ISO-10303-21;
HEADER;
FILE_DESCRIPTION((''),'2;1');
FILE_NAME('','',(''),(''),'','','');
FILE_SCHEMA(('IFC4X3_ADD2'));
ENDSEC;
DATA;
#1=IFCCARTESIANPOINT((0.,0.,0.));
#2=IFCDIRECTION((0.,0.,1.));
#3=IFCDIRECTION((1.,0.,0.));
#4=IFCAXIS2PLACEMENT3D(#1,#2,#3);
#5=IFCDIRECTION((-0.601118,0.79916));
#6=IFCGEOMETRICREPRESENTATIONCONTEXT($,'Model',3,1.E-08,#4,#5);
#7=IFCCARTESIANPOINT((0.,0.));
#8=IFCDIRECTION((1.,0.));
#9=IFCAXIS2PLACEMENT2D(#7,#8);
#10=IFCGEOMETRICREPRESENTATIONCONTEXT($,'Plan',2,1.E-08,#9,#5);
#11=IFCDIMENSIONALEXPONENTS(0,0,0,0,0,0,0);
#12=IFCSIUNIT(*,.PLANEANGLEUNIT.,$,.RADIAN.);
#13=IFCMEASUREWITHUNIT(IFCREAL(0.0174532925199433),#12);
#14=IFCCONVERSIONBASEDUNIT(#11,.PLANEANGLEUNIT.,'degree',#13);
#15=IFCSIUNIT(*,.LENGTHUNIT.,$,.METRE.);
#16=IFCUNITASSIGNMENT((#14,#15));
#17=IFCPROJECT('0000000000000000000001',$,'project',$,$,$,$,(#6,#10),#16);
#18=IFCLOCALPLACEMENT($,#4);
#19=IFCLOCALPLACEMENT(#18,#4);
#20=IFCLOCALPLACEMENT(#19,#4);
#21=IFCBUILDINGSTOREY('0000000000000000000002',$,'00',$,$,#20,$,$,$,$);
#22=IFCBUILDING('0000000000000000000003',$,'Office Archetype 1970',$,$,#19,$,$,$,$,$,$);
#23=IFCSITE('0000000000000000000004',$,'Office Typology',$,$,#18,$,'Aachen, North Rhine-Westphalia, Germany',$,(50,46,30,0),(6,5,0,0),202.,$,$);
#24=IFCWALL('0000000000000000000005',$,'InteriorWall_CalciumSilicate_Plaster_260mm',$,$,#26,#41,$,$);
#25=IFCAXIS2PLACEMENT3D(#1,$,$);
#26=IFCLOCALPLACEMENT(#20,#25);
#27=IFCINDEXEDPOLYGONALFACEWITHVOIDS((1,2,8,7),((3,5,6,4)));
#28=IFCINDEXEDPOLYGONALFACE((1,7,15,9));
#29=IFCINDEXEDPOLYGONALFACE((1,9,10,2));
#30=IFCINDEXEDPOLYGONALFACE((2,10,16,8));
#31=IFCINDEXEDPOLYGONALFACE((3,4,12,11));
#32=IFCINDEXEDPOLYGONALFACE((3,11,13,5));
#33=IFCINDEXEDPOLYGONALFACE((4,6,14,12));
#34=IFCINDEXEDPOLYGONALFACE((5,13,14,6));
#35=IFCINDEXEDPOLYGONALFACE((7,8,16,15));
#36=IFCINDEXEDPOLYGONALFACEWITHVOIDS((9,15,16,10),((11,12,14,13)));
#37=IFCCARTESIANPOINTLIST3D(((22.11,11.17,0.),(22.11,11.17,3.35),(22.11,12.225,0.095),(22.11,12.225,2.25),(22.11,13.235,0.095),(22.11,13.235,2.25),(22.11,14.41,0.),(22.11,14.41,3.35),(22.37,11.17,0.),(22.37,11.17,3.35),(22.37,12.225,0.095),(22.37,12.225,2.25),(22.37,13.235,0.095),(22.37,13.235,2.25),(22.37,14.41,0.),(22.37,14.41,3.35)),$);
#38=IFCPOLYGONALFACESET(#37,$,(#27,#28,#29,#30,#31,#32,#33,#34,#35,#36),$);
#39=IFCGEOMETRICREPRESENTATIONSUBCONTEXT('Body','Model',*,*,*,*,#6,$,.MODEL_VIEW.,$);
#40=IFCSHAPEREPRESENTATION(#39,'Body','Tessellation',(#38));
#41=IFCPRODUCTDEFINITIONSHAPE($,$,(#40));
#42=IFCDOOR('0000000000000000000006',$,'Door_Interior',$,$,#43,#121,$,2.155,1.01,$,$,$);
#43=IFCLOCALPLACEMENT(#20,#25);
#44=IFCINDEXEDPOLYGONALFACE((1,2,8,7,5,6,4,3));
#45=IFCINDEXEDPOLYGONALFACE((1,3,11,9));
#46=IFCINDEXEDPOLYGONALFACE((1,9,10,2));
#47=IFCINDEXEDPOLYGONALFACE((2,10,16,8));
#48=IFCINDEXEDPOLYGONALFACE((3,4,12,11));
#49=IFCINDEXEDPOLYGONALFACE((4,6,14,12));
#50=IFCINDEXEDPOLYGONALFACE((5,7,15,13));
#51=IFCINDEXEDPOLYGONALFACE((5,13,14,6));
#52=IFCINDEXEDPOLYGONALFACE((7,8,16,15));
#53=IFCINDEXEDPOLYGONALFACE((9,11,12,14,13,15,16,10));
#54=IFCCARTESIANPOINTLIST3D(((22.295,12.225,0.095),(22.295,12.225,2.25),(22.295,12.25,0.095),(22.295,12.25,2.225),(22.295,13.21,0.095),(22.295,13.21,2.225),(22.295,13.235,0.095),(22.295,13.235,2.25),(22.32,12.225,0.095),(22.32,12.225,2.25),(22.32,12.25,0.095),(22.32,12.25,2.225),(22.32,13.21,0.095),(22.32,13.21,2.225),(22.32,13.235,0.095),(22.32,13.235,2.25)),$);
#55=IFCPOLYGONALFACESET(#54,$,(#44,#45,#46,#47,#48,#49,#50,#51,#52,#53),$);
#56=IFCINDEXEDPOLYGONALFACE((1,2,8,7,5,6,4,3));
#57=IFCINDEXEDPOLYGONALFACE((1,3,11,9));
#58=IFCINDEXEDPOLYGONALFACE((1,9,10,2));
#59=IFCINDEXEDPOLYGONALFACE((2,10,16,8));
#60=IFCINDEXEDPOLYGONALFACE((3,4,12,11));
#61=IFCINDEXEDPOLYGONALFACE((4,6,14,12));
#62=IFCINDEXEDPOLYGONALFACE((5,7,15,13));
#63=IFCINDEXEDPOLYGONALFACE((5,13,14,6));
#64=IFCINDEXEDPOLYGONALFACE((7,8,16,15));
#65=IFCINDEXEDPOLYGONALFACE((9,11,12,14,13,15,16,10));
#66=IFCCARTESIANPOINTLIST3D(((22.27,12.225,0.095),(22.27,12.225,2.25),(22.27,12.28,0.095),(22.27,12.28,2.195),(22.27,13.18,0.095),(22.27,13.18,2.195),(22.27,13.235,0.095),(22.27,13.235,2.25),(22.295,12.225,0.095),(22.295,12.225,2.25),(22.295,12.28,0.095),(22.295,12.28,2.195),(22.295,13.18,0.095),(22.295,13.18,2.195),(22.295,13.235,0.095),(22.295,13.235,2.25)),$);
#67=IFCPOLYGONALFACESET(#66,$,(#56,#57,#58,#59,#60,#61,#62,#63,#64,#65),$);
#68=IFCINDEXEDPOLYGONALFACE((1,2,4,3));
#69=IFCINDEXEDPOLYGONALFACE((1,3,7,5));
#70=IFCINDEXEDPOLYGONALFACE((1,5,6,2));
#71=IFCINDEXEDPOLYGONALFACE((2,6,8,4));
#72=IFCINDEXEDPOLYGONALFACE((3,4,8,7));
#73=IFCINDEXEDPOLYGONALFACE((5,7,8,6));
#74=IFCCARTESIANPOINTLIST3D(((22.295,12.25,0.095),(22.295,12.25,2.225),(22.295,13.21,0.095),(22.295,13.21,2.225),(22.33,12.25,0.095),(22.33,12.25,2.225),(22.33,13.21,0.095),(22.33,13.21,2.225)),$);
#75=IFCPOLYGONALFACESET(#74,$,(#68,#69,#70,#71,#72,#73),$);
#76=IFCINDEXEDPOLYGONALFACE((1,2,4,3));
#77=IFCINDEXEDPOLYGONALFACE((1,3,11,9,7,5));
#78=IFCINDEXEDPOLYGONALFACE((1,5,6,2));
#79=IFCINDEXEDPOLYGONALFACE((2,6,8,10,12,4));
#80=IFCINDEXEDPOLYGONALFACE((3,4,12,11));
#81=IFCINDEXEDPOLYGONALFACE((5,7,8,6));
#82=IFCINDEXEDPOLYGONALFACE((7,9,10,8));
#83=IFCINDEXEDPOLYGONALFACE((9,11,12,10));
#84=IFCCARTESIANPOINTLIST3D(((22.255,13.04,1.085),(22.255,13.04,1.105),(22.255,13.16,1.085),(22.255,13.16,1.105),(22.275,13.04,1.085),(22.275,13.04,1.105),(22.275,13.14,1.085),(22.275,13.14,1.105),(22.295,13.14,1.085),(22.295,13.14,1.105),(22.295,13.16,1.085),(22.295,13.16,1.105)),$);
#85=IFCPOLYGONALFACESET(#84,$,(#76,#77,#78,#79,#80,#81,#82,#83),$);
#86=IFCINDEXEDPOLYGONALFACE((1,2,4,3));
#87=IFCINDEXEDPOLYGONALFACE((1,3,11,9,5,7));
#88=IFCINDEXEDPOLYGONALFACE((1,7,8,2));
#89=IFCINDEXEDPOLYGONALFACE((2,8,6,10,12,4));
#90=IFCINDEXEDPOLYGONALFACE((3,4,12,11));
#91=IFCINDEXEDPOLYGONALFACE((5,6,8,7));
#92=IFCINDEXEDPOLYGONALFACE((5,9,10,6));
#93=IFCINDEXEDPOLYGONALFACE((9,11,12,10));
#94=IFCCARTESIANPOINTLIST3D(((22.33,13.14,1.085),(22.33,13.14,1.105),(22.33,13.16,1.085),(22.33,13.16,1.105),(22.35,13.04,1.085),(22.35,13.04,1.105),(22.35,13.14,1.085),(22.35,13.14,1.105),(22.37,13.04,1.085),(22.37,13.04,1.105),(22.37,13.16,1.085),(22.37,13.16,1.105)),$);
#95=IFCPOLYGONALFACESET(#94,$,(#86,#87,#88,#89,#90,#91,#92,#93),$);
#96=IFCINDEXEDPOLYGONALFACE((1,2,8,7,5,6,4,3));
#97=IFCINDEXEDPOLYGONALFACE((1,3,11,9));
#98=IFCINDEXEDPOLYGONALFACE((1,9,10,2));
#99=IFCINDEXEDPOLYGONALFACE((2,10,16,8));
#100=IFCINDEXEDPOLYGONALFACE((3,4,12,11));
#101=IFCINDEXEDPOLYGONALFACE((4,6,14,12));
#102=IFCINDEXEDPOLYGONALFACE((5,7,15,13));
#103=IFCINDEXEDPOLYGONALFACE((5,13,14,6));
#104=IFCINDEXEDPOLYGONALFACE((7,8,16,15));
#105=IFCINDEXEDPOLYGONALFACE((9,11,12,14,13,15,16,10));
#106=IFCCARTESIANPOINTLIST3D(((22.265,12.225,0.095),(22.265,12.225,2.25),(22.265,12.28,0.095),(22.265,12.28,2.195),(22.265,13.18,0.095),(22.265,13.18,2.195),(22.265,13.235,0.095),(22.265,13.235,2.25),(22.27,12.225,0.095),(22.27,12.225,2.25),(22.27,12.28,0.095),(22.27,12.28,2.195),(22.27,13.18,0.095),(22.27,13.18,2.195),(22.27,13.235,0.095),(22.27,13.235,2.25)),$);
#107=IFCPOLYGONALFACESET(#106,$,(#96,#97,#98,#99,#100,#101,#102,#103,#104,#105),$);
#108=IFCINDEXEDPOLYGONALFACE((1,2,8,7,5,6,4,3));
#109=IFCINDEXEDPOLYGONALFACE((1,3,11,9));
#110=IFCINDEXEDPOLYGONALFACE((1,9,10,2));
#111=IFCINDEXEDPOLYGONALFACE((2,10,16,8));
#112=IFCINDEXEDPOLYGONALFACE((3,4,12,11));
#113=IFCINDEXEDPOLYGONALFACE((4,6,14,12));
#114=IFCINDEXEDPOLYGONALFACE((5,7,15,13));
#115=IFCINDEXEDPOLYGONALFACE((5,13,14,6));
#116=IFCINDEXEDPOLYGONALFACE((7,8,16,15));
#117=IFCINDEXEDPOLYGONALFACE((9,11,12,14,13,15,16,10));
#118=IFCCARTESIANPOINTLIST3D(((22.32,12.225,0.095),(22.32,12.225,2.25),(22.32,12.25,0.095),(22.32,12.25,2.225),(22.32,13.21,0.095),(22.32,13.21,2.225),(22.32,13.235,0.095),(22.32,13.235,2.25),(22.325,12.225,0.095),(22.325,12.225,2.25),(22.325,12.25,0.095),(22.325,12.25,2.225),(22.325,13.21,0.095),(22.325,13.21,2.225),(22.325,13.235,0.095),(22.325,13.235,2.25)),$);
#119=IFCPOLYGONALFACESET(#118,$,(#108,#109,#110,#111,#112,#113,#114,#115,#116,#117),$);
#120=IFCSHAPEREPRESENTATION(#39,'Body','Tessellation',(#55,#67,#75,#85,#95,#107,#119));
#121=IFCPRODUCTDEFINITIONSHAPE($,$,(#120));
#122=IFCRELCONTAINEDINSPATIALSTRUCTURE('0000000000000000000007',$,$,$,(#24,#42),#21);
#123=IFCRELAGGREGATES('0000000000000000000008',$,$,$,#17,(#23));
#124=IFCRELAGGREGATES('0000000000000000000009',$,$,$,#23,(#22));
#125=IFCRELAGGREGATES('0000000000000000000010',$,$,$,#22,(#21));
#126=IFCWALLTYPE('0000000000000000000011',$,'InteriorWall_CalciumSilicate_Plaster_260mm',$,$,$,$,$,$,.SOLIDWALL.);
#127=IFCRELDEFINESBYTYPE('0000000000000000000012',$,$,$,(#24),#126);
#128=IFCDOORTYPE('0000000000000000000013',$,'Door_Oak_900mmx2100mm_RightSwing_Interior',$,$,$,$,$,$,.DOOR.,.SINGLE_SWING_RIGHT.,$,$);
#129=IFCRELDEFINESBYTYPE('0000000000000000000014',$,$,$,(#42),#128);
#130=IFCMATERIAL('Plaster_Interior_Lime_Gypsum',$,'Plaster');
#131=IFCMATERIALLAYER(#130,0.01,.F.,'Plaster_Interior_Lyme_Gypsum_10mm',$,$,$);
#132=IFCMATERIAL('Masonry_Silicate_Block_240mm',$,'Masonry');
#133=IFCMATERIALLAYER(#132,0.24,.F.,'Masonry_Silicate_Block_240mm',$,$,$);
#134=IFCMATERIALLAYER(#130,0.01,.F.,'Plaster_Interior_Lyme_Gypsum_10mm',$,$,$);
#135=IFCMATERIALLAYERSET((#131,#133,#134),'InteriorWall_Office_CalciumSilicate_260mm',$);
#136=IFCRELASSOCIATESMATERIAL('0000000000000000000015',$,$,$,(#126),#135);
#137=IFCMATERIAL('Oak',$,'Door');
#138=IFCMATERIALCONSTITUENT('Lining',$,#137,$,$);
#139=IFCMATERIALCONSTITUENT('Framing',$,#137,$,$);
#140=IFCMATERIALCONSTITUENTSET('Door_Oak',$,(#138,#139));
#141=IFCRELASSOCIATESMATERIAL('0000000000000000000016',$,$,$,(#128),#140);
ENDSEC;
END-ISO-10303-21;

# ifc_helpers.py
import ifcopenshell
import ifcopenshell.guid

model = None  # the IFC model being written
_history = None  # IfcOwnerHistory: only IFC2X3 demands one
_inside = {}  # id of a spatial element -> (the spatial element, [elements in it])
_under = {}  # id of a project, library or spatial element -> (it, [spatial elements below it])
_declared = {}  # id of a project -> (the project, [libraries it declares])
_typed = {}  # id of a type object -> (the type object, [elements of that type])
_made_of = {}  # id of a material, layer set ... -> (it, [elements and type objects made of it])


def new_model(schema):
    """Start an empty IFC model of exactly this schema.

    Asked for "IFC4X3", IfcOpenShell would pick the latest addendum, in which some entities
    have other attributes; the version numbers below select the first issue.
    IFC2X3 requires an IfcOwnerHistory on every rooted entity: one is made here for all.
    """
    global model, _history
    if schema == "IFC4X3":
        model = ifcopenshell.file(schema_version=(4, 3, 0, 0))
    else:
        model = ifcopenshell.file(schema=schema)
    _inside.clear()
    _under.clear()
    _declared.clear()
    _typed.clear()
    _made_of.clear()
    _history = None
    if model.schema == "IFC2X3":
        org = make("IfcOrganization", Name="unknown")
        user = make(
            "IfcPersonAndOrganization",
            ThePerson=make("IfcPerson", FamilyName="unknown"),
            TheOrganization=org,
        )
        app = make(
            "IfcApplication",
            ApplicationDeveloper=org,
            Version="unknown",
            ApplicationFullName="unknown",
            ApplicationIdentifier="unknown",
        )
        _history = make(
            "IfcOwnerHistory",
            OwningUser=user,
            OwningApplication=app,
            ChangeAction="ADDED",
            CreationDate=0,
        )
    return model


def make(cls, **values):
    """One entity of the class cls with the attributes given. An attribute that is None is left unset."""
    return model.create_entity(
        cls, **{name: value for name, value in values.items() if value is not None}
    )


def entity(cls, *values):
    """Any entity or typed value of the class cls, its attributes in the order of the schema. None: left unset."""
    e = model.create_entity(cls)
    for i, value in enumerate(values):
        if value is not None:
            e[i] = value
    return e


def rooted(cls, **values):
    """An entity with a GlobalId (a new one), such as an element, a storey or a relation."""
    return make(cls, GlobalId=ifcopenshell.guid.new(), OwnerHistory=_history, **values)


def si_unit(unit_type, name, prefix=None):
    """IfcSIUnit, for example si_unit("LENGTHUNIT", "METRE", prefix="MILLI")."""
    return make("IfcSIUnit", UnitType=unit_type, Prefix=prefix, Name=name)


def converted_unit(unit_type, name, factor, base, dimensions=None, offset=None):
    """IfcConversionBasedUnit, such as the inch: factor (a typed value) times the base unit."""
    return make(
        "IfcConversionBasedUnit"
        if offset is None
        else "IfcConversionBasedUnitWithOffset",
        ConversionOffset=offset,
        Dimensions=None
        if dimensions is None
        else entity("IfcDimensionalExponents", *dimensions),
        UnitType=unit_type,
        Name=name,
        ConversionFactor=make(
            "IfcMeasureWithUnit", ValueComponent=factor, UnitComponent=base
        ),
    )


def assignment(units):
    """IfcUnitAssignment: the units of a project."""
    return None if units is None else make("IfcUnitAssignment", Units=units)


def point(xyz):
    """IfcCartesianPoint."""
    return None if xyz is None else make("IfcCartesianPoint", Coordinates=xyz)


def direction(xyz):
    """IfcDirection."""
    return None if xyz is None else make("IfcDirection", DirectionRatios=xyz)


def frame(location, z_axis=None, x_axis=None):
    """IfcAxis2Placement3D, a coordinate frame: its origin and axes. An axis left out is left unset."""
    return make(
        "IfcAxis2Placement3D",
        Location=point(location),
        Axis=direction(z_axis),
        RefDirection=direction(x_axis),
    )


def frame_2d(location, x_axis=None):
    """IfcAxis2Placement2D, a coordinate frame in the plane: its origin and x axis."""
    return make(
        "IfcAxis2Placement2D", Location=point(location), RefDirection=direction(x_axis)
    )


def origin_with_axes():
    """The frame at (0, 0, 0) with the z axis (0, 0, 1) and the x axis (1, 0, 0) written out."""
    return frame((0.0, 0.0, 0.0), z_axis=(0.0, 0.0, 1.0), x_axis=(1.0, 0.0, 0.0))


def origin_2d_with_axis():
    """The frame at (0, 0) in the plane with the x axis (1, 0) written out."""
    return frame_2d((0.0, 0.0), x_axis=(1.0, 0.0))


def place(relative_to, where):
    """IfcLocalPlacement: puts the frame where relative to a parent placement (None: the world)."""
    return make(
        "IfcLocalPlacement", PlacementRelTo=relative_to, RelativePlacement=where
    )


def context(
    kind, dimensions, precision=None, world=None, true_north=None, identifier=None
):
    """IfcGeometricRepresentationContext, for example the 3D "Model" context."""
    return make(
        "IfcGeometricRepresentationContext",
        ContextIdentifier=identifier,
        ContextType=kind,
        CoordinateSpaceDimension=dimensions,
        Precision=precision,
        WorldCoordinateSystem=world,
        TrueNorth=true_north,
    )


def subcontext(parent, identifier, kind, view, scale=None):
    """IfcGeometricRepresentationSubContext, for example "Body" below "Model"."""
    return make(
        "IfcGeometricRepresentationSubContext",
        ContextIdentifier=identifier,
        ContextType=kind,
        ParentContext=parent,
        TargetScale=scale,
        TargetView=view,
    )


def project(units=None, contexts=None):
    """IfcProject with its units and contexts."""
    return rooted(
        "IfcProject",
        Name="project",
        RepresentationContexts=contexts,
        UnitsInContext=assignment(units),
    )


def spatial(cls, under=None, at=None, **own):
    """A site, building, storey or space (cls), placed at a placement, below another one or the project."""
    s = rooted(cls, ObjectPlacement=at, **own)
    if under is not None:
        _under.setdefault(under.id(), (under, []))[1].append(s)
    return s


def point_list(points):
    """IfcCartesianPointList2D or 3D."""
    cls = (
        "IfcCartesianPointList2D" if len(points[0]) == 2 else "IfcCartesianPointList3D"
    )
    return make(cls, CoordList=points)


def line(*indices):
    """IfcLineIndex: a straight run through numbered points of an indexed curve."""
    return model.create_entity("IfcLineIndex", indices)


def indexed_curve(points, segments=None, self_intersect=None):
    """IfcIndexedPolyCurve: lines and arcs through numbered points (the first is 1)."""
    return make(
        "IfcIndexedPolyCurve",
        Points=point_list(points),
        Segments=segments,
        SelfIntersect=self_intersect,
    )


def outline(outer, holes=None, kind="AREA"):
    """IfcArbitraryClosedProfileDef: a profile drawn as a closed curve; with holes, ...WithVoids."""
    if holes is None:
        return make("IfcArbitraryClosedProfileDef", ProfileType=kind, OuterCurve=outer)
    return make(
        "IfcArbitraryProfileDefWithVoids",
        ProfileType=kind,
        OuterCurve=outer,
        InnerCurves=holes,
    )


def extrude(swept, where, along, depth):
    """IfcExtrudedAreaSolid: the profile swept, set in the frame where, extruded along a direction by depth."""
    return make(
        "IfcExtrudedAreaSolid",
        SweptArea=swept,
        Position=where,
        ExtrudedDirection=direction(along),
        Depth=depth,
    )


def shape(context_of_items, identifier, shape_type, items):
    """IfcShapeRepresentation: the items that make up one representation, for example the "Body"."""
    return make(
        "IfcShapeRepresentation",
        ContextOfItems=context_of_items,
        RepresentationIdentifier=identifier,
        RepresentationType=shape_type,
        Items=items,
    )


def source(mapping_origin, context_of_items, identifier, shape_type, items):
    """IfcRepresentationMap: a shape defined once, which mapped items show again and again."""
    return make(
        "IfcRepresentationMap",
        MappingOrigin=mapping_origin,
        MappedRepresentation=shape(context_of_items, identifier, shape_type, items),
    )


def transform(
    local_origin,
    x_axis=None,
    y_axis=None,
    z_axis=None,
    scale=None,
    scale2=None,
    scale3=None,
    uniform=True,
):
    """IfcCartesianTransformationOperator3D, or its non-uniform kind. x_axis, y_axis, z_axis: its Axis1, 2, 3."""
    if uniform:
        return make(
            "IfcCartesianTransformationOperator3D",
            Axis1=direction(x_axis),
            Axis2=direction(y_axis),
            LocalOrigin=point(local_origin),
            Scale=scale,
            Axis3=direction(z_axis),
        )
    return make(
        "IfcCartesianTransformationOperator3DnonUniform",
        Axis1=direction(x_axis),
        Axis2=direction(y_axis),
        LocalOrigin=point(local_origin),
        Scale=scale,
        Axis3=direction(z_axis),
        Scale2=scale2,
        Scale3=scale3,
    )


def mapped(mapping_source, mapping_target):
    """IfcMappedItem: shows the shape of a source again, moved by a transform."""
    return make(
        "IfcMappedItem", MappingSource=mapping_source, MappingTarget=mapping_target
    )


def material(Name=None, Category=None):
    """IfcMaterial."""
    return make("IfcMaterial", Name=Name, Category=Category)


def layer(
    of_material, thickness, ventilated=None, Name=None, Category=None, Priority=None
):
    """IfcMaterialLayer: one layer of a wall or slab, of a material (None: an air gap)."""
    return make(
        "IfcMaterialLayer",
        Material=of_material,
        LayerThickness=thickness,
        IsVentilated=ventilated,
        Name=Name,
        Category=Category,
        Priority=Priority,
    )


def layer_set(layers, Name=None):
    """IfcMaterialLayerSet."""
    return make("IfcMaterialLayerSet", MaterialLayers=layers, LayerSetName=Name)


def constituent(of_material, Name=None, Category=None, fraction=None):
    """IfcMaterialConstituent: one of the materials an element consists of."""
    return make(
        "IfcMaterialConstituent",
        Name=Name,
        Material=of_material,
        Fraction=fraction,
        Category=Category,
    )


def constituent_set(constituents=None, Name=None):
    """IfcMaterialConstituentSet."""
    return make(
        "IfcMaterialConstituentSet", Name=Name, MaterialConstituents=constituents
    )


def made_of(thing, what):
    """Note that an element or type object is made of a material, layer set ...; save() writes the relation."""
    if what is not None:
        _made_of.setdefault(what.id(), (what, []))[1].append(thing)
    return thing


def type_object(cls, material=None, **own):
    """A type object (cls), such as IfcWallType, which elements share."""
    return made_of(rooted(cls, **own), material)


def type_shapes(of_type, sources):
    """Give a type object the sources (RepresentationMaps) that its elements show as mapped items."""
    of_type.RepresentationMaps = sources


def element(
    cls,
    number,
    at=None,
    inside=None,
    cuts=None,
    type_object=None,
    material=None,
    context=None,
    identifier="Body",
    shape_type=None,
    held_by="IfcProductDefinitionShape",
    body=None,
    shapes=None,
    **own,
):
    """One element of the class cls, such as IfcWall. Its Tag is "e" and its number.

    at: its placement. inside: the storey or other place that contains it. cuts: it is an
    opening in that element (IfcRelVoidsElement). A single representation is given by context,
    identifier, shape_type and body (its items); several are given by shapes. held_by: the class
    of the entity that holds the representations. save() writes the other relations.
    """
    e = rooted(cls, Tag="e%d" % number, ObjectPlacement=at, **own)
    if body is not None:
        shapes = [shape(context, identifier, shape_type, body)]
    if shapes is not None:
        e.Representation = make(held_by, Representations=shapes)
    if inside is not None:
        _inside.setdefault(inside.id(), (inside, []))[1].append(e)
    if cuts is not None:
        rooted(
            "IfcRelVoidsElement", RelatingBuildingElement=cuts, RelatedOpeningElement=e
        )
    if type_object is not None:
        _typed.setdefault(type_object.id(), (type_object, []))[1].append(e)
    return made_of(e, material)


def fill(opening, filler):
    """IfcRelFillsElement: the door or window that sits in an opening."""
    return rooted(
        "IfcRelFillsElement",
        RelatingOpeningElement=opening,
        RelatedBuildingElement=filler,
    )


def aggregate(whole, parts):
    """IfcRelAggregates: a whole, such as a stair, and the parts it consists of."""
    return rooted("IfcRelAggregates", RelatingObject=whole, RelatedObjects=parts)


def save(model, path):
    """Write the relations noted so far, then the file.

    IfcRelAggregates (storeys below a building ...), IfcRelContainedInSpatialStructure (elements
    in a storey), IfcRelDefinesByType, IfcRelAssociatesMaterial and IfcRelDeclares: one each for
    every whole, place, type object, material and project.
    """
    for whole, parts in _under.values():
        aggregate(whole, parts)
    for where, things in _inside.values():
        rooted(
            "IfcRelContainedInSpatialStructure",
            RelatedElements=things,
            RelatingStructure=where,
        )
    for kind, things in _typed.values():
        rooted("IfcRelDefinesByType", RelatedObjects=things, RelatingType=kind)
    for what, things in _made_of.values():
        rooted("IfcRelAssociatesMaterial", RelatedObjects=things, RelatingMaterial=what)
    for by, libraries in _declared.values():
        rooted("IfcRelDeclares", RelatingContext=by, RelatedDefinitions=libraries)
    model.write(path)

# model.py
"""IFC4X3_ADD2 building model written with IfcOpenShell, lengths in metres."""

from ifc_helpers import new_model, entity, si_unit, converted_unit, direction, frame, origin_with_axes, origin_2d_with_axis, place, context, subcontext, project, spatial, line, indexed_curve, outline, extrude, source, transform, mapped, material, layer, layer_set, constituent, constituent_set, type_object, type_shapes, element, fill, save


model = new_model("IFC4X3_ADD2")

# Units and contexts
model_context = context("Model", 3, precision=1e-08, world=origin_with_axes(), true_north=direction((-0.601118, 0.79916)))
plan_context = context("Plan", 2, precision=1e-08, world=origin_2d_with_axis(), true_north=direction((-0.601118, 0.79916)))
body_context = subcontext(model_context, "Body", "Model", "MODEL_VIEW")
ifc_project = project(units=[converted_unit("PLANEANGLEUNIT", "degree", entity("IfcReal", 0.0174532925199433), si_unit("PLANEANGLEUNIT", "RADIAN"), dimensions=[0, 0, 0, 0, 0, 0, 0]), si_unit("LENGTHUNIT", "METRE")], contexts=[model_context, plan_context])

# Site, building, storey
site_placement = place(None, origin_with_axes())
site = spatial("IfcSite", under=ifc_project, at=site_placement, Name="Office Typology", LongName="Aachen, North Rhine-Westphalia, Germany", RefLatitude=(50, 46, 30, 0), RefLongitude=(6, 5, 0, 0), RefElevation=202.0)
building_placement = place(site_placement, origin_with_axes())
building = spatial("IfcBuilding", under=site, at=building_placement, Name="Office Archetype 1970")
storey_placement = place(building_placement, origin_with_axes())
storey = spatial("IfcBuildingStorey", under=building, at=storey_placement, Name="00")

# Wall, opening, door
ifc_material_1 = material(Name="Plaster_Interior_Lime_Gypsum", Category="Plaster")
ifc_layer_1 = layer(ifc_material_1, 0.01, ventilated=False, Name="Plaster_Interior_Lyme_Gypsum_10mm")
ifc_material_2 = material(Name="Masonry_Silicate_Block_240mm", Category="Masonry")
ifc_layer_2 = layer(ifc_material_2, 0.24, ventilated=False, Name="Masonry_Silicate_Block_240mm")
ifc_layer_3 = layer(ifc_material_1, 0.01, ventilated=False, Name="Plaster_Interior_Lyme_Gypsum_10mm")
ifc_layer_set = layer_set([ifc_layer_1, ifc_layer_2, ifc_layer_3], Name="InteriorWall_Office_CalciumSilicate_260mm")
wall_type = type_object("IfcWallType", Name="InteriorWall_CalciumSilicate_Plaster_260mm", PredefinedType="SOLIDWALL", material=ifc_layer_set)
wall_1_placement = place(storey_placement, frame((22.37, 11.17, 0.0), z_axis=(0.0, 0.0, 1.0), x_axis=(0.0, 1.0, 0.0)))
wall_1 = element("IfcWall", 1, at=wall_1_placement, inside=storey, type_object=wall_type, Name="InteriorWall_CalciumSilicate_Plaster_260mm", context=body_context, shape_type="SweptSolid", body=[
    extrude(outline(indexed_curve([(0.0, 0.0), (0.0, 0.26), (3.24, 0.26), (3.24, 0.0)], segments=[line(1, 2, 3, 4, 1)])), origin_with_axes(), (0.0, 0.0, 1.0), 3.35),
])
shared_shape_1 = source(origin_with_axes(), body_context, "Body", "SweptSolid", [
    extrude(outline(indexed_curve([(0.0, 0.0), (1.01, 0.0), (1.01, 2.155), (0.0, 2.155), (0.0, 0.0)])), frame((0.0, -0.015, 0.0), z_axis=(0.0, -1.0, 0.0), x_axis=(1.0, 0.0, 0.0)), (0.0, 0.0, -1.0), 0.26),
])
opening_1_placement = place(wall_1_placement, frame((2.065, 0.245, 0.095), z_axis=(0.0, 0.0, 1.0), x_axis=(-1.0, 0.0, 0.0)))
opening_1 = element("IfcOpeningElement", 2, at=opening_1_placement, cuts=wall_1, PredefinedType="OPENING", context=body_context, shape_type="MappedRepresentation", body=[
    mapped(shared_shape_1, transform((0.0, 0.0, 0.0), x_axis=(1.0, 0.0, 0.0), y_axis=(0.0, 1.0, 0.0), z_axis=(0.0, 0.0, 1.0), scale=1.0)),
])
ifc_material_3 = material(Name="Oak", Category="Door")
ifc_constituent_1 = constituent(ifc_material_3, Name="Lining")
ifc_constituent_2 = constituent(ifc_material_3, Name="Framing")
ifc_constituent_set_1 = constituent_set(constituents=[ifc_constituent_1, ifc_constituent_2], Name="Door_Oak")
door_type_1 = type_object("IfcDoorType", Name="Door_Oak_900mmx2100mm_RightSwing_Interior", OperationType="SINGLE_SWING_RIGHT", PredefinedType="DOOR", material=ifc_constituent_set_1)
shared_shape_2 = source(origin_with_axes(), body_context, "Body", "SweptSolid", [
    extrude(outline(indexed_curve([(0.0, 0.0), (0.0, 2.155), (1.01, 2.155), (1.01, 0.0), (0.985, 0.0), (0.985, 2.13), (0.025, 2.13), (0.025, 0.0)], segments=[line(1, 2, 3, 4, 5, 6, 7, 8, 1)])), frame((0.0, 0.025, 0.0), z_axis=(0.0, -1.0, 0.0), x_axis=(1.0, 0.0, 0.0)), (0.0, 0.0, -1.0), 0.025),
    extrude(outline(indexed_curve([(0.0, 0.0), (0.0, 2.155), (1.01, 2.155), (1.01, 0.0), (0.955, 0.0), (0.955, 2.1), (0.055, 2.1), (0.055, 0.0)], segments=[line(1, 2, 3, 4, 5, 6, 7, 8, 1)])), frame((0.0, 0.0, 0.0), z_axis=(0.0, -1.0, 0.0), x_axis=(1.0, 0.0, 0.0)), (0.0, 0.0, -1.0), 0.025),
    extrude(outline(indexed_curve([(0.0, 0.0), (0.96, 0.0), (0.96, 0.035), (0.0, 0.035)], segments=[line(1, 2, 3, 4, 1)])), frame((0.025, 0.025, 0.0), z_axis=(0.0, 0.0, 1.0), x_axis=(1.0, 0.0, 0.0)), (0.0, 0.0, 1.0), 2.13),
    extrude(outline(indexed_curve([(0.0, 0.0), (0.0, -0.04), (0.12, -0.04), (0.12, -0.02), (0.02, -0.02), (0.02, 0.0)], segments=[line(1, 2, 3, 4, 5, 6, 1)])), frame((0.075, 0.025, 0.99), z_axis=(0.0, 0.0, 1.0), x_axis=(1.0, 0.0, 0.0)), (0.0, 0.0, 1.0), 0.02),
    extrude(outline(indexed_curve([(0.0, 0.0), (0.0, 0.04), (0.12, 0.04), (0.12, 0.02), (0.02, 0.02), (0.02, 0.0)], segments=[line(1, 2, 3, 4, 5, 6, 1)])), frame((0.075, 0.06, 0.99), z_axis=(0.0, 0.0, 1.0), x_axis=(1.0, 0.0, 0.0)), (0.0, 0.0, 1.0), 0.02),
    extrude(outline(indexed_curve([(0.0, 0.0), (0.0, 2.155), (1.01, 2.155), (1.01, 0.0), (0.955, 0.0), (0.955, 2.1), (0.055, 2.1), (0.055, 0.0)], segments=[line(1, 2, 3, 4, 5, 6, 7, 8, 1)])), frame((0.0, -0.005, 0.0), z_axis=(0.0, -1.0, 0.0), x_axis=(1.0, 0.0, 0.0)), (0.0, 0.0, -1.0), 0.005),
    extrude(outline(indexed_curve([(0.0, 0.0), (0.0, 2.155), (1.01, 2.155), (1.01, 0.0), (0.985, 0.0), (0.985, 2.13), (0.025, 2.13), (0.025, 0.0)], segments=[line(1, 2, 3, 4, 5, 6, 7, 8, 1)])), frame((0.0, 0.05, 0.0), z_axis=(0.0, -1.0, 0.0), x_axis=(1.0, 0.0, 0.0)), (0.0, 0.0, -1.0), 0.005),
])
type_shapes(door_type_1, [shared_shape_2])
door_1_placement = place(opening_1_placement, frame((0.0, 0.145, 0.0), z_axis=(0.0, 0.0, 1.0), x_axis=(1.0, 0.0, 0.0)))
door_1 = element("IfcDoor", 3, at=door_1_placement, inside=storey, type_object=door_type_1, Name="Door_Interior", OverallHeight=2.155, OverallWidth=1.01, context=body_context, shape_type="MappedRepresentation", body=[
    mapped(shared_shape_2, transform((0.0, 0.0, 0.0), x_axis=(1.0, 0.0, 0.0), y_axis=(0.0, 1.0, 0.0), z_axis=(0.0, 0.0, 1.0), scale=1.0)),
])
fill(opening_1, door_1)

save(model, "model.ifc")
